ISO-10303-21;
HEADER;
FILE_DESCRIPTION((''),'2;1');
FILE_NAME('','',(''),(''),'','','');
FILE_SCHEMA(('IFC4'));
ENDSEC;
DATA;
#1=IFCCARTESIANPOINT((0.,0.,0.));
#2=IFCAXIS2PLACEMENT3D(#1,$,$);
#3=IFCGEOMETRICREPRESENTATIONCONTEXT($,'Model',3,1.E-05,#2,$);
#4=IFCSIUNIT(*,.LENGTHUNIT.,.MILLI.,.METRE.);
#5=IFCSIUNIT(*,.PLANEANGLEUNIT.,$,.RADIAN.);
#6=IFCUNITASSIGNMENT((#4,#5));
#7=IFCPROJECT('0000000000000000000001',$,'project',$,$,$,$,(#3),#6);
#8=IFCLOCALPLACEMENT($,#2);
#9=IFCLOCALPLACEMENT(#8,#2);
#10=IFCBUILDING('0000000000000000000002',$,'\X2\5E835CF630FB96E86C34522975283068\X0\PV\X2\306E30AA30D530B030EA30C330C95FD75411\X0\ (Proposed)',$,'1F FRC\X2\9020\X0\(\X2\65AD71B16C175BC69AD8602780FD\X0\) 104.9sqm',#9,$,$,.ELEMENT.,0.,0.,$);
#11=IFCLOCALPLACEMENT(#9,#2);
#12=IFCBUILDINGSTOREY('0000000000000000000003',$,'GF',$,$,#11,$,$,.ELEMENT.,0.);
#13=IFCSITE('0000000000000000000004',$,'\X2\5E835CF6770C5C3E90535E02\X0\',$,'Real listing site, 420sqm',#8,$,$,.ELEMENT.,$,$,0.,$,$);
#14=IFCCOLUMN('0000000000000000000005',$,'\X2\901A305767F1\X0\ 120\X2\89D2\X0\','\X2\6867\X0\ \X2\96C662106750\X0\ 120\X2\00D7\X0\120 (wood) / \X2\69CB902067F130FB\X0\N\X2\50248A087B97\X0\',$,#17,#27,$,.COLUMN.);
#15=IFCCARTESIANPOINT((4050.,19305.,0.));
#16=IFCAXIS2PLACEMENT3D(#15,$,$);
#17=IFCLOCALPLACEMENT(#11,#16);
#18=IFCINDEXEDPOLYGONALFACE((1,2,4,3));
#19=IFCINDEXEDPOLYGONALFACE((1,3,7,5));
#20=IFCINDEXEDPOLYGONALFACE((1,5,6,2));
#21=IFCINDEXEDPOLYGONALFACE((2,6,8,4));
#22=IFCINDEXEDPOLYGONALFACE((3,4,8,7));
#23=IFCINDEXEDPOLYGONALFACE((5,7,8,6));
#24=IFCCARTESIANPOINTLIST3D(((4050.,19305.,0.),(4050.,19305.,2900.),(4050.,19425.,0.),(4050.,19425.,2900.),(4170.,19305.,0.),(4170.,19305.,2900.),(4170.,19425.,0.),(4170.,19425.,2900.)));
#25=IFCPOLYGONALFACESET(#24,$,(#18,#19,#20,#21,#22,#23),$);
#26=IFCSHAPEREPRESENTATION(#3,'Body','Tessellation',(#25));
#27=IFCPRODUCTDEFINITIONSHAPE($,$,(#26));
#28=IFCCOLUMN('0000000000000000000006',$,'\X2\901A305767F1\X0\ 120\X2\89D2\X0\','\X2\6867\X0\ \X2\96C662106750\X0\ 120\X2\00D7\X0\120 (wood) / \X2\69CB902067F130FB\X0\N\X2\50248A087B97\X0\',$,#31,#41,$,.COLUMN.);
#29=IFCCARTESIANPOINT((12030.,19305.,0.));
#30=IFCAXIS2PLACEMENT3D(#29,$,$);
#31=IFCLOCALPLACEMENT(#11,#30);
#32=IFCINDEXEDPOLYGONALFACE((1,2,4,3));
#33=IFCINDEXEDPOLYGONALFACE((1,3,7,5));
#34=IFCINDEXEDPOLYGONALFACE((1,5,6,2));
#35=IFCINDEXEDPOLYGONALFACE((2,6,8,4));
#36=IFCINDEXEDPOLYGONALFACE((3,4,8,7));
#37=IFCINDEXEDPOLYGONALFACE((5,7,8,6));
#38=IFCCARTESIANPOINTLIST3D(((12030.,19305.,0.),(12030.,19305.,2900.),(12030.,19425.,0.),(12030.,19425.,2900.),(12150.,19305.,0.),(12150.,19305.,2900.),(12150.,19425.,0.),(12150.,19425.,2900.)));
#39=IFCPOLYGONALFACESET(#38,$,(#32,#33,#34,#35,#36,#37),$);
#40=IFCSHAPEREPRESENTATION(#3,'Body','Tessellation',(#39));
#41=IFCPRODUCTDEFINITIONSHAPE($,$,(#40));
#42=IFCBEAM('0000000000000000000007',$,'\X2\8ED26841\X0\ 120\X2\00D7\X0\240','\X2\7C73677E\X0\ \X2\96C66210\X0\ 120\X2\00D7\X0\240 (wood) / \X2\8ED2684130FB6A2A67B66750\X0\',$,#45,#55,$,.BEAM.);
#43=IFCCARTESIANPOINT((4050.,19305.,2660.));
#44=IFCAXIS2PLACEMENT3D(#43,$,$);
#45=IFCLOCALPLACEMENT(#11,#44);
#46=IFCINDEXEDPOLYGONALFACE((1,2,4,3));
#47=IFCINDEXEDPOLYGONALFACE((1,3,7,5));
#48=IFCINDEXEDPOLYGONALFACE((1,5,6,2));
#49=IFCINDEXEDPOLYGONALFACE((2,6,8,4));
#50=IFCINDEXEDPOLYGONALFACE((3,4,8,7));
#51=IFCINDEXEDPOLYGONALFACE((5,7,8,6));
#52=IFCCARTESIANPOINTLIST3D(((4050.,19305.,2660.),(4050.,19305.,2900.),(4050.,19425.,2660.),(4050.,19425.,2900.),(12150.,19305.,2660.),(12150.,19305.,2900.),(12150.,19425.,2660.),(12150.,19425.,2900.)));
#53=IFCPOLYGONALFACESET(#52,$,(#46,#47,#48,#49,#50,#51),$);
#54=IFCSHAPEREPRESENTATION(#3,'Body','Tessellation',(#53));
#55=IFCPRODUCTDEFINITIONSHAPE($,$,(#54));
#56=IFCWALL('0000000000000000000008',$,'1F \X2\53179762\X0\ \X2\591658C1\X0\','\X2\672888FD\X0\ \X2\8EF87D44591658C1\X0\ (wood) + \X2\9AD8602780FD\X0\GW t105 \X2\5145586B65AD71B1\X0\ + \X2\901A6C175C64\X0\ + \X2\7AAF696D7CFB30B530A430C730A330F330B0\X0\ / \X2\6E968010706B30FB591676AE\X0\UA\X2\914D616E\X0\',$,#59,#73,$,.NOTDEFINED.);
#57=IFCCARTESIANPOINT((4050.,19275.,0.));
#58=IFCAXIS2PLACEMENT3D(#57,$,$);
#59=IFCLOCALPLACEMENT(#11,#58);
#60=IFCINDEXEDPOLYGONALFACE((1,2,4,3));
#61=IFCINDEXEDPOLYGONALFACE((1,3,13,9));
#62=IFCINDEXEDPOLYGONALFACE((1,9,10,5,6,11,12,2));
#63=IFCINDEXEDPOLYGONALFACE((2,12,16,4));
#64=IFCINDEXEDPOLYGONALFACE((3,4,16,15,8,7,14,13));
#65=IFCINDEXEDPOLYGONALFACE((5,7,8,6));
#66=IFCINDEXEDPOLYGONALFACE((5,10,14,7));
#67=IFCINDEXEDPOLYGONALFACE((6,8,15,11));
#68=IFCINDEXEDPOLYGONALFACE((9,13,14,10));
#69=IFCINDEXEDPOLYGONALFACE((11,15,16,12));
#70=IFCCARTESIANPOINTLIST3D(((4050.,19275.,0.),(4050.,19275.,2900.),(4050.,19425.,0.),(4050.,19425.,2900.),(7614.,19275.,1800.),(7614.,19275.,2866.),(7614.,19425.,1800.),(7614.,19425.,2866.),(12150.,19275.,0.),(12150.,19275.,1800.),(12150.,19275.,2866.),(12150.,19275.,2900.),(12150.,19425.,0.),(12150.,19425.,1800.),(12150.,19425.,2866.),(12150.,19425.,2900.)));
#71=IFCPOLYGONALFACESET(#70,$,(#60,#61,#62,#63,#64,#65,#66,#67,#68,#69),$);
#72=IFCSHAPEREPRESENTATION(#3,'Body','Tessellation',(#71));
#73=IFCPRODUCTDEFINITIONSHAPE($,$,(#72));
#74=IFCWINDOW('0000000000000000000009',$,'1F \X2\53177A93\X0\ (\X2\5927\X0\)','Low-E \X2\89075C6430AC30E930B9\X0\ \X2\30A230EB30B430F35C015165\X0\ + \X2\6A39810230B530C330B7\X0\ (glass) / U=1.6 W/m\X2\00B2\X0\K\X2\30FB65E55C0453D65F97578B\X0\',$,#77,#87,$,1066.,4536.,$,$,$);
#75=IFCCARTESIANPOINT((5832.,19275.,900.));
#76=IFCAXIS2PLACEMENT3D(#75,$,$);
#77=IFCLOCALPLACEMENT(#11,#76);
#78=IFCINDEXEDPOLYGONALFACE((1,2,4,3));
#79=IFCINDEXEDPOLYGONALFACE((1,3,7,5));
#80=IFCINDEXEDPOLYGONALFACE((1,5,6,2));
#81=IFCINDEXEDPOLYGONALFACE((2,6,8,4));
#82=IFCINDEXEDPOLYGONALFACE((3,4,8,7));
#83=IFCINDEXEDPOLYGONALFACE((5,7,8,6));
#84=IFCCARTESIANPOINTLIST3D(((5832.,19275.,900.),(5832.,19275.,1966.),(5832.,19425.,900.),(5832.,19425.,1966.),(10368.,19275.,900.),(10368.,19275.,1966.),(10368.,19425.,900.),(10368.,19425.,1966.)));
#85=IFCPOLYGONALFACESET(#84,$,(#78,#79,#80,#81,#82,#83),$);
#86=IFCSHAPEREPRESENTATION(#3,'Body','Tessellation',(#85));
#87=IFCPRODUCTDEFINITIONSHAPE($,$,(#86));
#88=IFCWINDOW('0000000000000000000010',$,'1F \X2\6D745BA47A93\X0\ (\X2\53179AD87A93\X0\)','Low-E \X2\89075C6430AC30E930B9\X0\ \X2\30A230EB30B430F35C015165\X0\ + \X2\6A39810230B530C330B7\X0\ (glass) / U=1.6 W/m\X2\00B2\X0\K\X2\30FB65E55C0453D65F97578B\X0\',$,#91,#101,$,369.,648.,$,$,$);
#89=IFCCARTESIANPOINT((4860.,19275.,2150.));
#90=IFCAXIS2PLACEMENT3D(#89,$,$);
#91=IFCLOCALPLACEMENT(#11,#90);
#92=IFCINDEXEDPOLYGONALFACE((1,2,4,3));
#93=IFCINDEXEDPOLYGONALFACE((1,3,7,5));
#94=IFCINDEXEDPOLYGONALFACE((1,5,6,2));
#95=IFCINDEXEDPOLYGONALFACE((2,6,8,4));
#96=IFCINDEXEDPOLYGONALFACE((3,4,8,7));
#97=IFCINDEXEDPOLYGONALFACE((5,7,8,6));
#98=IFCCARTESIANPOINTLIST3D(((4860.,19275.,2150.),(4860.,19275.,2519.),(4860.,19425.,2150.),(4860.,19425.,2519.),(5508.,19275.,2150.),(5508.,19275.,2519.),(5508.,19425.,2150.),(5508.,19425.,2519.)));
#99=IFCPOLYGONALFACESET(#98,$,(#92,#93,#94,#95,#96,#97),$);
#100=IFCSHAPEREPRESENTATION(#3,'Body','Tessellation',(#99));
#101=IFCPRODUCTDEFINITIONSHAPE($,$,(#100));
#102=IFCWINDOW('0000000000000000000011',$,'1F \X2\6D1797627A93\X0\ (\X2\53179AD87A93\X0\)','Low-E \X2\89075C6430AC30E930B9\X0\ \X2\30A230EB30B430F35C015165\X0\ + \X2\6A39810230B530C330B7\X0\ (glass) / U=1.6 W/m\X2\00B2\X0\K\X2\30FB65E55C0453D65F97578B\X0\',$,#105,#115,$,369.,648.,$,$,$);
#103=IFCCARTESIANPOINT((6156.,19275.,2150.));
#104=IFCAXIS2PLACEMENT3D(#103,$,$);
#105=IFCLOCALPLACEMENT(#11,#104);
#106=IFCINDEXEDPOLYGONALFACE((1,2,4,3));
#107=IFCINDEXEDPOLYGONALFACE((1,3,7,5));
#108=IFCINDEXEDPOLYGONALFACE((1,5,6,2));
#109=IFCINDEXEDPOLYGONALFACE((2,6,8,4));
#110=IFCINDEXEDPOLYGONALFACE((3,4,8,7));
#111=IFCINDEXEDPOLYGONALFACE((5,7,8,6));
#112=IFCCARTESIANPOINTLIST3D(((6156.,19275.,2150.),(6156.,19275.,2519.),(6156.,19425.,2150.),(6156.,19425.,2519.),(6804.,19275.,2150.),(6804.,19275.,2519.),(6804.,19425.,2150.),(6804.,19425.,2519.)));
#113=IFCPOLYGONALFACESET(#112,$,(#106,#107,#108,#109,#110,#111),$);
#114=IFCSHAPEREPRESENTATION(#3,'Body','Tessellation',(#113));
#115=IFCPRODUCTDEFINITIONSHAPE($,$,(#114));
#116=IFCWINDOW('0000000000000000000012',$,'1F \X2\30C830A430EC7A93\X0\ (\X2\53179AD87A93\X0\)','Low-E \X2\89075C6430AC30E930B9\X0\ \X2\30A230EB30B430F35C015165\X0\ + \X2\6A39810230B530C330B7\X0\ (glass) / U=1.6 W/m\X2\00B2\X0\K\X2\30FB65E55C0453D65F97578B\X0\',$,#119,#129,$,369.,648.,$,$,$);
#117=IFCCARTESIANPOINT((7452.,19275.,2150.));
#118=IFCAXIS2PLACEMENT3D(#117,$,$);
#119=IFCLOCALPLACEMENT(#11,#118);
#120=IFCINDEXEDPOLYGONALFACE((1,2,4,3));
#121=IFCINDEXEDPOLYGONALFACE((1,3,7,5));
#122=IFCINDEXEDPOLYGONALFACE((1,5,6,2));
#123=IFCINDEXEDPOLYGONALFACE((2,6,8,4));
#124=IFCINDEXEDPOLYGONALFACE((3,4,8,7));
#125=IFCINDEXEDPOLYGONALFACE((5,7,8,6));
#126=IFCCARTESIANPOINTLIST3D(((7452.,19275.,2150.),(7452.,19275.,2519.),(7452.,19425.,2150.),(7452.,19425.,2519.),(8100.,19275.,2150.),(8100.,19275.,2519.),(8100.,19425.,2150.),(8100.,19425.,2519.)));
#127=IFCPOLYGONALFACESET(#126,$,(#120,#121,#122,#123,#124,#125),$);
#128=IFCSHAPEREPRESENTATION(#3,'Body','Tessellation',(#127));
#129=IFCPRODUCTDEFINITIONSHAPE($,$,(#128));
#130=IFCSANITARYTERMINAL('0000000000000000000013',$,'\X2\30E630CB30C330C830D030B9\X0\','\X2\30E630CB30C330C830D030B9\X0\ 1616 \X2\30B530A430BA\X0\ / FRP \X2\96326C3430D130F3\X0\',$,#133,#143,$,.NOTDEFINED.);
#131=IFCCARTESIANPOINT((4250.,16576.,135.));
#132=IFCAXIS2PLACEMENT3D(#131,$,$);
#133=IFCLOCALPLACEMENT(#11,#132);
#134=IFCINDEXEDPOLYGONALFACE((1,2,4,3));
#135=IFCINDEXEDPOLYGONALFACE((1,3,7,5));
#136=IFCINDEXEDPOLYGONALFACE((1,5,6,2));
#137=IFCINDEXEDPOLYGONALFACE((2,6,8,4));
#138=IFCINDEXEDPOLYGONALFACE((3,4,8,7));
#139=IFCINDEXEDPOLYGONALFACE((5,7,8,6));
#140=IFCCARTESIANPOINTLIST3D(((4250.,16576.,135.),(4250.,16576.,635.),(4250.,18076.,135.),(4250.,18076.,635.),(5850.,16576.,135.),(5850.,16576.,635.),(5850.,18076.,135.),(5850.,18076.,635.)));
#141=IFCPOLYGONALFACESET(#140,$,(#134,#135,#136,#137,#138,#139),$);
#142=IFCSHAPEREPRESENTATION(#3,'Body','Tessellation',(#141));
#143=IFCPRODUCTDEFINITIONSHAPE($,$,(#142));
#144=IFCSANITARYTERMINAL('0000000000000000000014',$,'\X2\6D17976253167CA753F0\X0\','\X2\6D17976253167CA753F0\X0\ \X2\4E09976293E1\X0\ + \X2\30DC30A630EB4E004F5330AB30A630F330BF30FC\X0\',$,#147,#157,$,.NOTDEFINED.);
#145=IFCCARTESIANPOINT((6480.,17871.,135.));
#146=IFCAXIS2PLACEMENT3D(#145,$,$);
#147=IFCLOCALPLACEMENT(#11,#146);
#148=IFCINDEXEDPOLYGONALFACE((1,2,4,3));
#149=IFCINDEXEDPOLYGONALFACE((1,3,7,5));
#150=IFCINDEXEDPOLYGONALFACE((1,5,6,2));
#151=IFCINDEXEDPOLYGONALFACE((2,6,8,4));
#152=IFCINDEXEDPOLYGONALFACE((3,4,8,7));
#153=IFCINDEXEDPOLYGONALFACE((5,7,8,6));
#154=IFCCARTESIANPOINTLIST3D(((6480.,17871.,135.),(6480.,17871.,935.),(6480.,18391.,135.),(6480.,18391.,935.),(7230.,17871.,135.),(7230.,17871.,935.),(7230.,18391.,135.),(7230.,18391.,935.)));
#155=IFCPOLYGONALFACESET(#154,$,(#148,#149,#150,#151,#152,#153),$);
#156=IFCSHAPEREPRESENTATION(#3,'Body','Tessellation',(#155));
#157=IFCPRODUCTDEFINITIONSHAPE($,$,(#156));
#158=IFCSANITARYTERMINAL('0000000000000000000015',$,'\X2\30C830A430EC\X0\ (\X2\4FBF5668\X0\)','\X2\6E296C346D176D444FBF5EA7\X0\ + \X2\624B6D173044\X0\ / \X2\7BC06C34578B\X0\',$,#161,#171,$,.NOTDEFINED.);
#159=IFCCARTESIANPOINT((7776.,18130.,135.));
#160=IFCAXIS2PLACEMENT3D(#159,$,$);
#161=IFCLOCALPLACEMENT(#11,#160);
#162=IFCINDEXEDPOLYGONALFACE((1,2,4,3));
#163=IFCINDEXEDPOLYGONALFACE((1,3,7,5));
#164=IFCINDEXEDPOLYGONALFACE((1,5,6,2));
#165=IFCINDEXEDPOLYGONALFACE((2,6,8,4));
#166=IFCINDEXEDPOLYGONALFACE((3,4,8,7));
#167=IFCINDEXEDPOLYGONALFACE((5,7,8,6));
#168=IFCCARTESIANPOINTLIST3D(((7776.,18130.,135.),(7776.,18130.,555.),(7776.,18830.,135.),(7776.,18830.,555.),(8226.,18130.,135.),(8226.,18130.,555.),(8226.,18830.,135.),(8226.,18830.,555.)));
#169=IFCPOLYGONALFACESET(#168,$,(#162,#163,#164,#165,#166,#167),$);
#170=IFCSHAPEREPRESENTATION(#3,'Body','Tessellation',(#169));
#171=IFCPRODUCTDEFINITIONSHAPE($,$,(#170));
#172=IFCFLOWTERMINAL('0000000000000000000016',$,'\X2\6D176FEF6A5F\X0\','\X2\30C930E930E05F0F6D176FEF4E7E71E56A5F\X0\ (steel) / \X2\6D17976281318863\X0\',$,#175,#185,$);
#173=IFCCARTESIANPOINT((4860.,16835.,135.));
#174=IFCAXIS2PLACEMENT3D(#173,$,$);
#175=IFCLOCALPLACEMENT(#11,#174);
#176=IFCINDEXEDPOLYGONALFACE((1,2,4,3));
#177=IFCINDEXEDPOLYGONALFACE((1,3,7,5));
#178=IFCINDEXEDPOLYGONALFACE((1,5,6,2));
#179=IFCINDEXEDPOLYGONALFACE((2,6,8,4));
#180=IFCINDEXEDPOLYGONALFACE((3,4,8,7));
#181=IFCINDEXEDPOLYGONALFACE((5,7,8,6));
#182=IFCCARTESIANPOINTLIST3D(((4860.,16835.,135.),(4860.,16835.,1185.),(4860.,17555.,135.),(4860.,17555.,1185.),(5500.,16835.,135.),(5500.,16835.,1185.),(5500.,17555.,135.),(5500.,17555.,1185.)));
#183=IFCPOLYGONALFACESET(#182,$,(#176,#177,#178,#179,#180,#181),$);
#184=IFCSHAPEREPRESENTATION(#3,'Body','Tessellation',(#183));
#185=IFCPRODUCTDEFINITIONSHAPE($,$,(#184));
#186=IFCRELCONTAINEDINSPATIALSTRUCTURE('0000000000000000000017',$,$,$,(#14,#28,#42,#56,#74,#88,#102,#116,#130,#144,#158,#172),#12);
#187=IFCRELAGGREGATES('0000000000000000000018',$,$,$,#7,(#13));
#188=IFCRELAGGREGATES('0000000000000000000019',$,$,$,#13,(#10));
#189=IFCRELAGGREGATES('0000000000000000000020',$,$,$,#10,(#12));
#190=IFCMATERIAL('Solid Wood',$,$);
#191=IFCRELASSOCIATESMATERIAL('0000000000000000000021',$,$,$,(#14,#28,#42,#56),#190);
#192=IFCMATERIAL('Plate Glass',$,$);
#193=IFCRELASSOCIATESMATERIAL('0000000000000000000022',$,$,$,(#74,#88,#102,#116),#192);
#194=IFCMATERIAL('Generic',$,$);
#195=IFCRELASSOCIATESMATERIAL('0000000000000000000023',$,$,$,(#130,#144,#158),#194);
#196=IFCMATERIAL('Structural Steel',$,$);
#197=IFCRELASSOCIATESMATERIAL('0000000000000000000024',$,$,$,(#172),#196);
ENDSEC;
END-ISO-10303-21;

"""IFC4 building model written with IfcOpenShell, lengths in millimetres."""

from ifc_helpers import new_model, si_unit, frame, frame_2d, origin, place, context, project, spatial, rectangle, extrude, material, element, fill, save


model = new_model("IFC4")

# Units and contexts
model_context = context("Model", 3, precision=1e-05, world=origin())
ifc_project = project(units=[si_unit("LENGTHUNIT", "METRE", prefix="MILLI"), si_unit("PLANEANGLEUNIT", "RADIAN")], contexts=[model_context])

# Site, building, storey
site_placement = place(None, origin())
site = spatial("IfcSite", under=ifc_project, at=site_placement, Name="広島県尾道市", ObjectType="Real listing site, 420sqm", CompositionType="ELEMENT", RefElevation=0.0)
building_placement = place(site_placement, origin())
building = spatial("IfcBuilding", under=site, at=building_placement, Name="広島・雨水利用とPVのオフグリッド志向 (Proposed)", ObjectType="1F FRC造(断熱気密高性能) 104.9sqm", CompositionType="ELEMENT", ElevationOfRefHeight=0.0, ElevationOfTerrain=0.0)
storey_placement = place(building_placement, origin())
storey = spatial("IfcBuildingStorey", under=building, at=storey_placement, Name="GF", CompositionType="ELEMENT", Elevation=0.0)

# Columns
ifc_material_1 = material(Name="Solid Wood")
column_1_placement = place(storey_placement, frame((4050.0, 19305.0, 0.0)))
element("IfcColumn", 1, at=column_1_placement, inside=storey, material=ifc_material_1, Name="通し柱 120角", Description="桧 集成材 120×120 (wood) / 構造柱・N値計算", PredefinedType="COLUMN", context=model_context, shape_type="SweptSolid", body=[
    extrude(rectangle(XDim=120.0, YDim=120.0, at=frame_2d((60.0, 60.0))), frame((4050.0, 19305.0, 0.0)), (0.0, 0.0, 1.0), 2900.0),
])
column_2_placement = place(storey_placement, frame((12030.0, 19305.0, 0.0)))
element("IfcColumn", 2, at=column_2_placement, inside=storey, material=ifc_material_1, Name="通し柱 120角", Description="桧 集成材 120×120 (wood) / 構造柱・N値計算", PredefinedType="COLUMN", context=model_context, shape_type="SweptSolid", body=[
    extrude(rectangle(XDim=120.0, YDim=120.0, at=frame_2d((60.0, 60.0))), frame((12030.0, 19305.0, 0.0)), (0.0, 0.0, 1.0), 2900.0),
])

# Beam
beam_1_placement = place(storey_placement, frame((4050.0, 19305.0, 2660.0)))
element("IfcBeam", 3, at=beam_1_placement, inside=storey, material=ifc_material_1, Name="軒桁 120×240", Description="米松 集成 120×240 (wood) / 軒桁・横架材", PredefinedType="BEAM", context=model_context, shape_type="SweptSolid", body=[
    extrude(rectangle(XDim=8100.0, YDim=120.0, at=frame_2d((4050.0, 60.0))), frame((4050.0, 19305.0, 2660.0)), (0.0, 0.0, 1.0), 240.0),
])

# Wall, openings, windows
wall_1_placement = place(storey_placement, frame((4050.0, 19275.0, 0.0)))
wall_1 = element("IfcWall", 4, at=wall_1_placement, inside=storey, material=ifc_material_1, Name="1F 北面 外壁", Description="木製 軸組外壁 (wood) + 高性能GW t105 充填断熱 + 通気層 + 窯業系サイディング / 準耐火・外皮UA配慮", PredefinedType="NOTDEFINED", context=model_context, shape_type="SweptSolid", body=[
    extrude(rectangle(XDim=8100.0, YDim=150.0, at=frame_2d((4050.0, 75.0))), frame((4050.0, 19275.0, 0.0)), (0.0, 0.0, 1.0), 2900.0),
])
opening_1_placement = place(storey_placement, frame((5832.0, 19275.0, 900.0)))
opening_1 = element("IfcOpeningElement", 5, at=opening_1_placement, cuts=wall_1, PredefinedType="NOTDEFINED", context=model_context, shape_type="SweptSolid", body=[
    extrude(rectangle(XDim=4536.0, YDim=150.0, at=frame_2d((2268.0, 75.0))), frame((5832.0, 19275.0, 900.0)), (0.0, 0.0, 1.0), 1066.0),
])
opening_2_placement = place(storey_placement, frame((4860.0, 19275.0, 2150.0)))
opening_2 = element("IfcOpeningElement", 6, at=opening_2_placement, cuts=wall_1, PredefinedType="NOTDEFINED", context=model_context, shape_type="SweptSolid", body=[
    extrude(rectangle(XDim=648.0, YDim=150.0, at=frame_2d((324.0, 75.0))), frame((4860.0, 19275.0, 2150.0)), (0.0, 0.0, 1.0), 369.0),
])
opening_3_placement = place(storey_placement, frame((6156.0, 19275.0, 2150.0)))
opening_3 = element("IfcOpeningElement", 7, at=opening_3_placement, cuts=wall_1, PredefinedType="NOTDEFINED", context=model_context, shape_type="SweptSolid", body=[
    extrude(rectangle(XDim=648.0, YDim=150.0, at=frame_2d((324.0, 75.0))), frame((6156.0, 19275.0, 2150.0)), (0.0, 0.0, 1.0), 369.0),
])
opening_4_placement = place(storey_placement, frame((7452.0, 19275.0, 2150.0)))
opening_4 = element("IfcOpeningElement", 8, at=opening_4_placement, cuts=wall_1, PredefinedType="NOTDEFINED", context=model_context, shape_type="SweptSolid", body=[
    extrude(rectangle(XDim=648.0, YDim=150.0, at=frame_2d((324.0, 75.0))), frame((7452.0, 19275.0, 2150.0)), (0.0, 0.0, 1.0), 369.0),
])
ifc_material_2 = material(Name="Plate Glass")
window_1_placement = place(storey_placement, frame((5832.0, 19275.0, 900.0)))
window_1 = element("IfcWindow", 9, at=window_1_placement, inside=storey, material=ifc_material_2, Name="1F 北窓 (大)", Description="Low-E 複層ガラス アルゴン封入 + 樹脂サッシ (glass) / U=1.6 W/m²K・日射取得型", OverallHeight=1066.0, OverallWidth=4536.0, context=model_context, shape_type="SweptSolid", body=[
    extrude(rectangle(XDim=4536.0, YDim=150.0, at=frame_2d((2268.0, 75.0))), frame((5832.0, 19275.0, 900.0)), (0.0, 0.0, 1.0), 1066.0),
])
fill(opening_1, window_1)
window_2_placement = place(storey_placement, frame((4860.0, 19275.0, 2150.0)))
window_2 = element("IfcWindow", 10, at=window_2_placement, inside=storey, material=ifc_material_2, Name="1F 浴室窓 (北高窓)", Description="Low-E 複層ガラス アルゴン封入 + 樹脂サッシ (glass) / U=1.6 W/m²K・日射取得型", OverallHeight=369.0, OverallWidth=648.0, context=model_context, shape_type="SweptSolid", body=[
    extrude(rectangle(XDim=648.0, YDim=150.0, at=frame_2d((324.0, 75.0))), frame((4860.0, 19275.0, 2150.0)), (0.0, 0.0, 1.0), 369.0),
])
fill(opening_2, window_2)
window_3_placement = place(storey_placement, frame((6156.0, 19275.0, 2150.0)))
window_3 = element("IfcWindow", 11, at=window_3_placement, inside=storey, material=ifc_material_2, Name="1F 洗面窓 (北高窓)", Description="Low-E 複層ガラス アルゴン封入 + 樹脂サッシ (glass) / U=1.6 W/m²K・日射取得型", OverallHeight=369.0, OverallWidth=648.0, context=model_context, shape_type="SweptSolid", body=[
    extrude(rectangle(XDim=648.0, YDim=150.0, at=frame_2d((324.0, 75.0))), frame((6156.0, 19275.0, 2150.0)), (0.0, 0.0, 1.0), 369.0),
])
fill(opening_3, window_3)
window_4_placement = place(storey_placement, frame((7452.0, 19275.0, 2150.0)))
window_4 = element("IfcWindow", 12, at=window_4_placement, inside=storey, material=ifc_material_2, Name="1F トイレ窓 (北高窓)", Description="Low-E 複層ガラス アルゴン封入 + 樹脂サッシ (glass) / U=1.6 W/m²K・日射取得型", OverallHeight=369.0, OverallWidth=648.0, context=model_context, shape_type="SweptSolid", body=[
    extrude(rectangle(XDim=648.0, YDim=150.0, at=frame_2d((324.0, 75.0))), frame((7452.0, 19275.0, 2150.0)), (0.0, 0.0, 1.0), 369.0),
])
fill(opening_4, window_4)

# Sanitary terminals
ifc_material_3 = material(Name="Generic")
sanitary_terminal_1_placement = place(storey_placement, frame((4250.0, 16576.0, 135.0)))
element("IfcSanitaryTerminal", 13, at=sanitary_terminal_1_placement, inside=storey, material=ifc_material_3, Name="ユニットバス", Description="ユニットバス 1616 サイズ / FRP 防水パン", PredefinedType="NOTDEFINED", context=model_context, shape_type="SweptSolid", body=[
    extrude(rectangle(XDim=1600.0, YDim=1500.0, at=frame_2d((800.0, 750.0))), frame((4250.0, 16576.0, 135.0)), (0.0, 0.0, 1.0), 500.0),
])
sanitary_terminal_2_placement = place(storey_placement, frame((6480.0, 17871.0, 135.0)))
element("IfcSanitaryTerminal", 14, at=sanitary_terminal_2_placement, inside=storey, material=ifc_material_3, Name="洗面化粧台", Description="洗面化粧台 三面鏡 + ボウル一体カウンター", PredefinedType="NOTDEFINED", context=model_context, shape_type="SweptSolid", body=[
    extrude(rectangle(XDim=750.0, YDim=520.0, at=frame_2d((375.0, 260.0))), frame((6480.0, 17871.0, 135.0)), (0.0, 0.0, 1.0), 800.0),
])
sanitary_terminal_3_placement = place(storey_placement, frame((7776.0, 18130.0, 135.0)))
element("IfcSanitaryTerminal", 15, at=sanitary_terminal_3_placement, inside=storey, material=ifc_material_3, Name="トイレ (便器)", Description="温水洗浄便座 + 手洗い / 節水型", PredefinedType="NOTDEFINED", context=model_context, shape_type="SweptSolid", body=[
    extrude(rectangle(XDim=450.0, YDim=700.0, at=frame_2d((225.0, 350.0))), frame((7776.0, 18130.0, 135.0)), (0.0, 0.0, 1.0), 420.0),
])

# Flow terminal
ifc_material_4 = material(Name="Structural Steel")
flow_terminal_placement = place(storey_placement, frame((4860.0, 16835.0, 135.0)))
element("IfcFlowTerminal", 16, at=flow_terminal_placement, inside=storey, material=ifc_material_4, Name="洗濯機", Description="ドラム式洗濯乾燥機 (steel) / 洗面脱衣", context=model_context, shape_type="SweptSolid", body=[
    extrude(rectangle(XDim=640.0, YDim=720.0, at=frame_2d((320.0, 360.0))), frame((4860.0, 16835.0, 135.0)), (0.0, 0.0, 1.0), 1050.0),
])

save(model, "model.ifc")
